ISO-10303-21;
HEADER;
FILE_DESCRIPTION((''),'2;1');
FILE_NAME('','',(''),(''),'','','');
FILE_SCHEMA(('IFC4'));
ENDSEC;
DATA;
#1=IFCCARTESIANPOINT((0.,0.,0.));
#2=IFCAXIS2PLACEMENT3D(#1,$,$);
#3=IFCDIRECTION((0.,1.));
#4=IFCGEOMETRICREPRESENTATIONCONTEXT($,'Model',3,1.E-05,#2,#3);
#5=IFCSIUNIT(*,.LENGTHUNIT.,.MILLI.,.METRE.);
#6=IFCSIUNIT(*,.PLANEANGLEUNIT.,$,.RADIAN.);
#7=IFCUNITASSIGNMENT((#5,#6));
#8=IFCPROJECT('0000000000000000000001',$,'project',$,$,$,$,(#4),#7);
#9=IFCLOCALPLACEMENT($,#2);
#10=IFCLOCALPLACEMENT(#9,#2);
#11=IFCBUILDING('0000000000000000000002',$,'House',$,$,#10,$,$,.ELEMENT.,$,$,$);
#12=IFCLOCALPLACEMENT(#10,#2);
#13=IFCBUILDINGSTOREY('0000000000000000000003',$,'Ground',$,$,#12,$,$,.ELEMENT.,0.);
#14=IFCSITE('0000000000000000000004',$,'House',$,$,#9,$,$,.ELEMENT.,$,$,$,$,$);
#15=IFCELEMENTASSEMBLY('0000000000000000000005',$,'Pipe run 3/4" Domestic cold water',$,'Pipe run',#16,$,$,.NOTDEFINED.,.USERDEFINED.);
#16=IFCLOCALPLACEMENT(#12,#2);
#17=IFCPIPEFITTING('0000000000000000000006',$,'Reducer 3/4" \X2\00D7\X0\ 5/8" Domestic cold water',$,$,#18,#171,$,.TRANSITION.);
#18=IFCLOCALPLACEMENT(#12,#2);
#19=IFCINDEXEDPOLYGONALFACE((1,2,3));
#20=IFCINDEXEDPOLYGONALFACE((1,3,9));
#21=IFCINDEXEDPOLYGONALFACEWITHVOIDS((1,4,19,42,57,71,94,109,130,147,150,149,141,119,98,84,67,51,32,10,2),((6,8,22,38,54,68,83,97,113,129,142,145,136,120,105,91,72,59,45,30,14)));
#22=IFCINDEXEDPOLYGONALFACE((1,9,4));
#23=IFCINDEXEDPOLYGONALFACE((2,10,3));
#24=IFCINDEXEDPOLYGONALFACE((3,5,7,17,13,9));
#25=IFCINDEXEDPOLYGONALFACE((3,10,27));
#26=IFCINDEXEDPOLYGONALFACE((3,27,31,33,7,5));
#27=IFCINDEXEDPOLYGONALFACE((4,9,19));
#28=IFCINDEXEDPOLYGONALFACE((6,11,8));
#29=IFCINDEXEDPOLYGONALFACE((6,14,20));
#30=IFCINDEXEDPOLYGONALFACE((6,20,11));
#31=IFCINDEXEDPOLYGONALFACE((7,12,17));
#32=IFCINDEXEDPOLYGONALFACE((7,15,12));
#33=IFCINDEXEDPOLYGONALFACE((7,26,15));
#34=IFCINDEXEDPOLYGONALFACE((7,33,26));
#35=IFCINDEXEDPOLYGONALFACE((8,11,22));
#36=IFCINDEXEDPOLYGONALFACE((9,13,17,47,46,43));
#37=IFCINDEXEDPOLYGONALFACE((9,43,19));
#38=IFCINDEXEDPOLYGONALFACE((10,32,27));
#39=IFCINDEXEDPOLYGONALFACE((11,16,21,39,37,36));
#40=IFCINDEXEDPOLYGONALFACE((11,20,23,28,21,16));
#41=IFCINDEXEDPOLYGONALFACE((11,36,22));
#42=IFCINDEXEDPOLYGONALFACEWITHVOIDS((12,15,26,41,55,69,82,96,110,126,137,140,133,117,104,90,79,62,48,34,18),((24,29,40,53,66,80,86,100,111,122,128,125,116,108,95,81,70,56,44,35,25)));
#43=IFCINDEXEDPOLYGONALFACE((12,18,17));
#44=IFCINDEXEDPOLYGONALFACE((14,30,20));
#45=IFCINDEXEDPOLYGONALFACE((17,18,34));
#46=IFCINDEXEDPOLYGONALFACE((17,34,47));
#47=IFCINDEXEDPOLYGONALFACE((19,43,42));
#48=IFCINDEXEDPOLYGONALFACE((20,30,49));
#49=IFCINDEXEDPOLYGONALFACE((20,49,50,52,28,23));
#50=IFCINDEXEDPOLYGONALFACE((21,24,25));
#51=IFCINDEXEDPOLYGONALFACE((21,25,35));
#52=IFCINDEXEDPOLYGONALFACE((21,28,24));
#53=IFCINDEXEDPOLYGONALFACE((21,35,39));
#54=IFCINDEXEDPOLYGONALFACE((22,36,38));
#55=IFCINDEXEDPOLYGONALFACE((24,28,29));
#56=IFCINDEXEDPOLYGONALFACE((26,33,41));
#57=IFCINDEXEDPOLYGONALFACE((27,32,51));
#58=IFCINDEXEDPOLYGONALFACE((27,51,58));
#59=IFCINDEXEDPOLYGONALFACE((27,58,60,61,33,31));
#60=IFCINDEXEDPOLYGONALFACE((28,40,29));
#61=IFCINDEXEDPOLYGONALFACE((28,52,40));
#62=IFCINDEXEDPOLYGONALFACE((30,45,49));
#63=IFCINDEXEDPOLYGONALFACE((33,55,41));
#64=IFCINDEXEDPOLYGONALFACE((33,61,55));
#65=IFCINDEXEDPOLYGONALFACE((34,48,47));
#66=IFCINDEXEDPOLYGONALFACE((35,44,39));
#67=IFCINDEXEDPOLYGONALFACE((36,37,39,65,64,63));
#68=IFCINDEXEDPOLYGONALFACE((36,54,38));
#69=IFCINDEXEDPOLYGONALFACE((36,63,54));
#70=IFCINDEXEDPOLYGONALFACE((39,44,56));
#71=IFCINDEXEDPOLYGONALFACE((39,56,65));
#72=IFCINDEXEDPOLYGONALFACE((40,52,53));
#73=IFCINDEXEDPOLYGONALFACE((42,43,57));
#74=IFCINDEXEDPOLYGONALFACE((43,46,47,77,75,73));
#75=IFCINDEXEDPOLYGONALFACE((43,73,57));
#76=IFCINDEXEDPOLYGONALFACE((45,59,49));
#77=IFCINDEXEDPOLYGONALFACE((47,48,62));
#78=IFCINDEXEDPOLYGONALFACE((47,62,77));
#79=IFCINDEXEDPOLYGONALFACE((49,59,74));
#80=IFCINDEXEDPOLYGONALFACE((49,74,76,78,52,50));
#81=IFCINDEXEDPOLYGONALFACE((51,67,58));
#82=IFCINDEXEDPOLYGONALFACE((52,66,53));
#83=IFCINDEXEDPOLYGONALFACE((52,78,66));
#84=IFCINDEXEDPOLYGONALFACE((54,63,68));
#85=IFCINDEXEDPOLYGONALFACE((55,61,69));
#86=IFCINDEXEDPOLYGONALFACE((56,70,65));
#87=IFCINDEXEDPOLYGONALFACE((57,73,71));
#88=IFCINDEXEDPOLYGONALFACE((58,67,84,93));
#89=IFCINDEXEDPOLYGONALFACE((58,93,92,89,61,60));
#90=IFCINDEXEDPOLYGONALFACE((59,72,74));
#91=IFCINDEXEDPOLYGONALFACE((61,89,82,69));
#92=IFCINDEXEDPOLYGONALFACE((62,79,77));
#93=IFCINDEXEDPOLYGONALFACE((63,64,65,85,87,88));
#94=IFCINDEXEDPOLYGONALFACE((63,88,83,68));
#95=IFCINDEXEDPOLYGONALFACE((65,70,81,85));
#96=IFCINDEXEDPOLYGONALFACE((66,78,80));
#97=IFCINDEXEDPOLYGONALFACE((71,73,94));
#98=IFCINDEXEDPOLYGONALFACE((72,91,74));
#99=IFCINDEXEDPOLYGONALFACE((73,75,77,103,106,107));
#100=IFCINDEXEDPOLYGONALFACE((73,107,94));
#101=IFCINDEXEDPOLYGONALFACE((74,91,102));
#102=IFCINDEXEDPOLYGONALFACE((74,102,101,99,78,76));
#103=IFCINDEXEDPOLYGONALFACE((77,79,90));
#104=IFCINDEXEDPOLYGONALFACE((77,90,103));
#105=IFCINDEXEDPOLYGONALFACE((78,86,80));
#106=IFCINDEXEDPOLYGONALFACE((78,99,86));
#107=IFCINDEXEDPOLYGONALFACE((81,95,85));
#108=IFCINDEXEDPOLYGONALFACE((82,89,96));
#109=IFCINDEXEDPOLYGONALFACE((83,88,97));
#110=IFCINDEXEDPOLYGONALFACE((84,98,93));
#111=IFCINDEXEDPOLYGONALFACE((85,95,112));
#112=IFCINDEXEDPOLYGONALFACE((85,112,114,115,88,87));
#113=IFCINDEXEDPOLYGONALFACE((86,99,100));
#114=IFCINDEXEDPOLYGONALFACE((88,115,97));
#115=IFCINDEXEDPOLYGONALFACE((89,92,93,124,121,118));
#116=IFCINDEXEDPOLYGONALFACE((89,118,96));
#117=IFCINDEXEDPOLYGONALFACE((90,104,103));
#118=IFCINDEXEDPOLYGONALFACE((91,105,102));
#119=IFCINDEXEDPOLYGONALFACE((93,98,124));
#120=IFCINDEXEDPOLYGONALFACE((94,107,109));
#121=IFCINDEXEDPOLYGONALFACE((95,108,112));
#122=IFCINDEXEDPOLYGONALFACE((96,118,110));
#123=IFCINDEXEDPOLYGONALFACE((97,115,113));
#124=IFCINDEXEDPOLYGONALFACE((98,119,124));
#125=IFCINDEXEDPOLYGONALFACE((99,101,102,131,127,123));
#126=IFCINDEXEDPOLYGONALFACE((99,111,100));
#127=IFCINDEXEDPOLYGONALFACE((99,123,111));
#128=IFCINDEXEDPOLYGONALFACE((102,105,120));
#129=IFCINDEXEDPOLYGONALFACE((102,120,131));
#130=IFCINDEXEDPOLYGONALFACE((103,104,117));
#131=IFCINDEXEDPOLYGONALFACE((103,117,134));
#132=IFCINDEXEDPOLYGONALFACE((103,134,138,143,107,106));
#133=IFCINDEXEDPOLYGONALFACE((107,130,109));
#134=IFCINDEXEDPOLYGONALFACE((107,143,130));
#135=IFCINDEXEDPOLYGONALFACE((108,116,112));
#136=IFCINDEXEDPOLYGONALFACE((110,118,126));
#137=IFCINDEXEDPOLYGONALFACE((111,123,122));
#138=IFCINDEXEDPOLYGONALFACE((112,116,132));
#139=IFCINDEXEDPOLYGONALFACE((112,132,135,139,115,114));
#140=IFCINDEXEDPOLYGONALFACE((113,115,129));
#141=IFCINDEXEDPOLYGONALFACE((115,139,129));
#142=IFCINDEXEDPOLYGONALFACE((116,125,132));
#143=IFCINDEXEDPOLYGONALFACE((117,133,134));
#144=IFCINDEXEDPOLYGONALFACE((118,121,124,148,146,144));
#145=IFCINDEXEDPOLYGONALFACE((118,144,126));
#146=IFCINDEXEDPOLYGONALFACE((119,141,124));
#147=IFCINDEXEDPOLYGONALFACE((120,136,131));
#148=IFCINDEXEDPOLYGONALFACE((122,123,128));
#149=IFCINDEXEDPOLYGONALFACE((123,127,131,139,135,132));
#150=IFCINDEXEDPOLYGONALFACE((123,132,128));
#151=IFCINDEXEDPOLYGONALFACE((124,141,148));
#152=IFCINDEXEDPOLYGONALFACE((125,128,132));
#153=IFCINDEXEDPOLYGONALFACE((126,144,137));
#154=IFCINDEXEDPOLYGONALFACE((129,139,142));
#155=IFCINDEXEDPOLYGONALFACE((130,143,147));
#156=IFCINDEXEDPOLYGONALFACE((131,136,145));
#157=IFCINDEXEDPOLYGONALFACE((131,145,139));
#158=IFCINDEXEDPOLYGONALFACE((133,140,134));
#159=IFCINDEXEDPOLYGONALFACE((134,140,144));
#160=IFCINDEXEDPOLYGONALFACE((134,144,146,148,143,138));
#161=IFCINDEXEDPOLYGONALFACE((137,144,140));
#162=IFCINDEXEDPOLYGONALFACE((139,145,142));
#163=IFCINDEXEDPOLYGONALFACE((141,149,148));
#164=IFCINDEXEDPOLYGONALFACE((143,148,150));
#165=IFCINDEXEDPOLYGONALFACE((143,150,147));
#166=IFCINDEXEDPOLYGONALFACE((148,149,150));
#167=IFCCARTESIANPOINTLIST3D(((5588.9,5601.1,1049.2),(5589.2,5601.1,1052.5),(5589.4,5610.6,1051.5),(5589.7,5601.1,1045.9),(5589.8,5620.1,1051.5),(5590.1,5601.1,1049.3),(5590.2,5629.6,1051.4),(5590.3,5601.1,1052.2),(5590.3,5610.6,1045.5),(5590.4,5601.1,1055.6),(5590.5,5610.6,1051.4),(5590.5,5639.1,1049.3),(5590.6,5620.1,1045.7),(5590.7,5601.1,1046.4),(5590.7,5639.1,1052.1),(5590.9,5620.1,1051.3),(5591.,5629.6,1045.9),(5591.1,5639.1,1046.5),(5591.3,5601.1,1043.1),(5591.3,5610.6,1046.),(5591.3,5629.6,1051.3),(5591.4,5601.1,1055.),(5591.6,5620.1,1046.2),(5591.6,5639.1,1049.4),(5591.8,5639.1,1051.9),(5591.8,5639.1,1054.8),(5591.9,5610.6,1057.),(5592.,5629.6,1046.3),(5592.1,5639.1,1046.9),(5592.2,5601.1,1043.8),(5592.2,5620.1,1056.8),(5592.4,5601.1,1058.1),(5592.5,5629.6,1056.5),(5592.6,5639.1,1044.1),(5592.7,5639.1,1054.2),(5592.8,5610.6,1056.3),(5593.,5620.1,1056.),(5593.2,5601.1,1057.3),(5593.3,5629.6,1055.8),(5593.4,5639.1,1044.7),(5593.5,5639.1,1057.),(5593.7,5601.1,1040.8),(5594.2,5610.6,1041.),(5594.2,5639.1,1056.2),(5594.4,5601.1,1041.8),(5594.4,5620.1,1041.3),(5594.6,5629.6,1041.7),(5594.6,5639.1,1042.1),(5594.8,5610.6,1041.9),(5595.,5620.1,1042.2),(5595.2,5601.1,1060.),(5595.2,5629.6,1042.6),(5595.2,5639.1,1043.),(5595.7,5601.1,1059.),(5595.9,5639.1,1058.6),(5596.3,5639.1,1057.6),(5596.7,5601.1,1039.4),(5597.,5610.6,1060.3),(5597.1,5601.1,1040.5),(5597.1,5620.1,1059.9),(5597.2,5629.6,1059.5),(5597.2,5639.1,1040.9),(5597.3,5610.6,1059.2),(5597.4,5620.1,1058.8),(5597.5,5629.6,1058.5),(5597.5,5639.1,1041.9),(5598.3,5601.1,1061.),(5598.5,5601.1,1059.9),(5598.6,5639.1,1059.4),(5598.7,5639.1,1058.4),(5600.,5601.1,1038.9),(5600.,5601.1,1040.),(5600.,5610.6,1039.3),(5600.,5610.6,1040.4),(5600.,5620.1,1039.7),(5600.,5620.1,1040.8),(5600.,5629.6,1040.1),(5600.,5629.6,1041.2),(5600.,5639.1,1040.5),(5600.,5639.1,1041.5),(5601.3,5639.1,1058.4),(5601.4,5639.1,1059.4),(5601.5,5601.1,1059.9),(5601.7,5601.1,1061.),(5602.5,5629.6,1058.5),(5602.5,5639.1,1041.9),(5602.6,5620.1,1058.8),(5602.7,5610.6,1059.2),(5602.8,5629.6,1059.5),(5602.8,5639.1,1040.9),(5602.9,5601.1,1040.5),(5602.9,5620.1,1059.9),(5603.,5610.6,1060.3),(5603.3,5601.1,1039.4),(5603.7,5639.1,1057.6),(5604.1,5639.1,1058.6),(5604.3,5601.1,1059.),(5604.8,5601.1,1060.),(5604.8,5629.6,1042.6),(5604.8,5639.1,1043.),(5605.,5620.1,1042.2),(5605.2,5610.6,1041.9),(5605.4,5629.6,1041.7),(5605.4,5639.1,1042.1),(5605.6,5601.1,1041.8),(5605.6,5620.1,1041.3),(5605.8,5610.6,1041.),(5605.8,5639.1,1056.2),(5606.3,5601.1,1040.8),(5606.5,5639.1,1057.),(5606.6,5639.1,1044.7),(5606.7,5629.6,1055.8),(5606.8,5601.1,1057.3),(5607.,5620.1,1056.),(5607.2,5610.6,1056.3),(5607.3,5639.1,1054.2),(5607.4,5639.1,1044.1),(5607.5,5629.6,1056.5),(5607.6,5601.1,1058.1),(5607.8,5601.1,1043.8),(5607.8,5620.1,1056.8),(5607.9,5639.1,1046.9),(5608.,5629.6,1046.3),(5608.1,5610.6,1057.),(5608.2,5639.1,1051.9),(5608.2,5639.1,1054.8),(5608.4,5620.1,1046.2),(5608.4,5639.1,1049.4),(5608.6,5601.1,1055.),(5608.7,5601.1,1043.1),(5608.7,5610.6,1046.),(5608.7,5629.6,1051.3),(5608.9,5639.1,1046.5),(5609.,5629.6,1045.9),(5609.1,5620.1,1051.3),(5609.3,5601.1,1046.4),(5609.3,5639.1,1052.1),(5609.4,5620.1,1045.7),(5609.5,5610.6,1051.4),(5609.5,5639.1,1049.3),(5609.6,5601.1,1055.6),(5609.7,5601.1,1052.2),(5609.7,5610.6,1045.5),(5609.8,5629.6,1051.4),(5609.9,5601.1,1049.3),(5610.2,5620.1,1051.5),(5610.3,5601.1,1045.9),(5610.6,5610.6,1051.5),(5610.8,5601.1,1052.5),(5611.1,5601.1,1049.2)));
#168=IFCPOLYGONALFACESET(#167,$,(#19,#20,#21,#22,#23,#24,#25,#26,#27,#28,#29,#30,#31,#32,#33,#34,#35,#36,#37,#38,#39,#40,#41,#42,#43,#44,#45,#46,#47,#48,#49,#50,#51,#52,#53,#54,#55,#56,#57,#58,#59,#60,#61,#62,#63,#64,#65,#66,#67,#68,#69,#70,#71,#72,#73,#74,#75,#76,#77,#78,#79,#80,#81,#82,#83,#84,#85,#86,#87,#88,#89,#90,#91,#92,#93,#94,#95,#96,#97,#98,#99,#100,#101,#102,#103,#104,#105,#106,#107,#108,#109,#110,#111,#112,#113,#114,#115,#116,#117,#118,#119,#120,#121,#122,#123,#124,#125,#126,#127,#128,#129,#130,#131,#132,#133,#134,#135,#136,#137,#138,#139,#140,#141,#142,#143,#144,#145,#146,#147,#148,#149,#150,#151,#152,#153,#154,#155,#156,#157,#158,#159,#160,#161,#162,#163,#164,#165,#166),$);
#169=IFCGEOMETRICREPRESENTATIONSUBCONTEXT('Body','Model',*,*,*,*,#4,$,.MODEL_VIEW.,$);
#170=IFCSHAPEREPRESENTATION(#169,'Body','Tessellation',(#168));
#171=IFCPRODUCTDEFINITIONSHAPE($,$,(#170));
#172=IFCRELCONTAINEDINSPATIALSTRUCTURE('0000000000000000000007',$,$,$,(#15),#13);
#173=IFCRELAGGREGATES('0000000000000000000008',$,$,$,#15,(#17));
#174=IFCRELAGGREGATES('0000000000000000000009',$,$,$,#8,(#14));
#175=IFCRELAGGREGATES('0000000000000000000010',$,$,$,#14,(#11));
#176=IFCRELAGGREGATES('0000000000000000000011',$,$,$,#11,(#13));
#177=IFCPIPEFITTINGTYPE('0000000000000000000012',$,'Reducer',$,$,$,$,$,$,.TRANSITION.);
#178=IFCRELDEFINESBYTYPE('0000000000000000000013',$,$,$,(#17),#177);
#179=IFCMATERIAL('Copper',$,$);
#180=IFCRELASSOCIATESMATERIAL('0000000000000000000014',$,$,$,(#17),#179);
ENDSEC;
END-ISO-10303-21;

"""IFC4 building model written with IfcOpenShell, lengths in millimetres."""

from ifc_helpers import new_model, entity, si_unit, direction, origin, origin_with_axes, place, context, subcontext, project, spatial, material, type_object, element, aggregate, save


model = new_model("IFC4")

# Units and contexts
model_context = context("Model", 3, precision=1e-05, world=origin(), true_north=direction((0.0, 1.0)))
body_context = subcontext(model_context, "Body", "Model", "MODEL_VIEW")
ifc_project = project(units=[si_unit("LENGTHUNIT", "METRE", prefix="MILLI"), si_unit("PLANEANGLEUNIT", "RADIAN")], contexts=[model_context])

# Site, building, storey
site_placement = place(None, origin())
site = spatial("IfcSite", under=ifc_project, at=site_placement, Name="House", CompositionType="ELEMENT")
building_placement = place(site_placement, origin())
building = spatial("IfcBuilding", under=site, at=building_placement, Name="House", CompositionType="ELEMENT")
storey_placement = place(building_placement, origin())
storey = spatial("IfcBuildingStorey", under=building, at=storey_placement, Name="Ground", CompositionType="ELEMENT", Elevation=0.0)

# Element assembly
ifc_material = material(Name="Copper")
assembly_1_placement = place(storey_placement, origin_with_axes())
assembly_1 = element("IfcElementAssembly", 1, at=assembly_1_placement, inside=storey, Name="Pipe run 3/4\" Domestic cold water", ObjectType="Pipe run", AssemblyPlace="NOTDEFINED", PredefinedType="USERDEFINED")

# Shared definitions
pipe_fitting_type_1 = type_object("IfcPipeFittingType", Name="Reducer", PredefinedType="TRANSITION")

# Pipe fitting
pipe_fitting_1_placement = place(storey_placement, origin_with_axes())
cartesian_point_1 = entity("IfcCartesianPoint", [0.0, 10.0])
pipe_fitting_1 = element("IfcPipeFitting", 2, at=pipe_fitting_1_placement, type_object=pipe_fitting_type_1, material=ifc_material, Name="Reducer 3/4\" × 5/8\" Domestic cold water", PredefinedType="TRANSITION", context=body_context, shape_type="SweptSolid", body=[
    entity("IfcRevolvedAreaSolid", entity("IfcArbitraryClosedProfileDef", "AREA", None, entity("IfcPolyline", [cartesian_point_1, entity("IfcCartesianPoint", [0.0, 11.1]), entity("IfcCartesianPoint", [38.0, 9.5]), entity("IfcCartesianPoint", [38.0, 8.5]), cartesian_point_1])), entity("IfcAxis2Placement3D", entity("IfcCartesianPoint", [5600.0, 5601.1, 1050.0]), entity("IfcDirection", [-1.0, 0.0, 0.0]), entity("IfcDirection", [0.0, 1.0, 0.0])), entity("IfcAxis1Placement", entity("IfcCartesianPoint", [0.0, 0.0, 0.0]), entity("IfcDirection", [1.0, 0.0, 0.0])), 6.283185),
])
aggregate(assembly_1, [pipe_fitting_1])

save(model, "model.ifc")
